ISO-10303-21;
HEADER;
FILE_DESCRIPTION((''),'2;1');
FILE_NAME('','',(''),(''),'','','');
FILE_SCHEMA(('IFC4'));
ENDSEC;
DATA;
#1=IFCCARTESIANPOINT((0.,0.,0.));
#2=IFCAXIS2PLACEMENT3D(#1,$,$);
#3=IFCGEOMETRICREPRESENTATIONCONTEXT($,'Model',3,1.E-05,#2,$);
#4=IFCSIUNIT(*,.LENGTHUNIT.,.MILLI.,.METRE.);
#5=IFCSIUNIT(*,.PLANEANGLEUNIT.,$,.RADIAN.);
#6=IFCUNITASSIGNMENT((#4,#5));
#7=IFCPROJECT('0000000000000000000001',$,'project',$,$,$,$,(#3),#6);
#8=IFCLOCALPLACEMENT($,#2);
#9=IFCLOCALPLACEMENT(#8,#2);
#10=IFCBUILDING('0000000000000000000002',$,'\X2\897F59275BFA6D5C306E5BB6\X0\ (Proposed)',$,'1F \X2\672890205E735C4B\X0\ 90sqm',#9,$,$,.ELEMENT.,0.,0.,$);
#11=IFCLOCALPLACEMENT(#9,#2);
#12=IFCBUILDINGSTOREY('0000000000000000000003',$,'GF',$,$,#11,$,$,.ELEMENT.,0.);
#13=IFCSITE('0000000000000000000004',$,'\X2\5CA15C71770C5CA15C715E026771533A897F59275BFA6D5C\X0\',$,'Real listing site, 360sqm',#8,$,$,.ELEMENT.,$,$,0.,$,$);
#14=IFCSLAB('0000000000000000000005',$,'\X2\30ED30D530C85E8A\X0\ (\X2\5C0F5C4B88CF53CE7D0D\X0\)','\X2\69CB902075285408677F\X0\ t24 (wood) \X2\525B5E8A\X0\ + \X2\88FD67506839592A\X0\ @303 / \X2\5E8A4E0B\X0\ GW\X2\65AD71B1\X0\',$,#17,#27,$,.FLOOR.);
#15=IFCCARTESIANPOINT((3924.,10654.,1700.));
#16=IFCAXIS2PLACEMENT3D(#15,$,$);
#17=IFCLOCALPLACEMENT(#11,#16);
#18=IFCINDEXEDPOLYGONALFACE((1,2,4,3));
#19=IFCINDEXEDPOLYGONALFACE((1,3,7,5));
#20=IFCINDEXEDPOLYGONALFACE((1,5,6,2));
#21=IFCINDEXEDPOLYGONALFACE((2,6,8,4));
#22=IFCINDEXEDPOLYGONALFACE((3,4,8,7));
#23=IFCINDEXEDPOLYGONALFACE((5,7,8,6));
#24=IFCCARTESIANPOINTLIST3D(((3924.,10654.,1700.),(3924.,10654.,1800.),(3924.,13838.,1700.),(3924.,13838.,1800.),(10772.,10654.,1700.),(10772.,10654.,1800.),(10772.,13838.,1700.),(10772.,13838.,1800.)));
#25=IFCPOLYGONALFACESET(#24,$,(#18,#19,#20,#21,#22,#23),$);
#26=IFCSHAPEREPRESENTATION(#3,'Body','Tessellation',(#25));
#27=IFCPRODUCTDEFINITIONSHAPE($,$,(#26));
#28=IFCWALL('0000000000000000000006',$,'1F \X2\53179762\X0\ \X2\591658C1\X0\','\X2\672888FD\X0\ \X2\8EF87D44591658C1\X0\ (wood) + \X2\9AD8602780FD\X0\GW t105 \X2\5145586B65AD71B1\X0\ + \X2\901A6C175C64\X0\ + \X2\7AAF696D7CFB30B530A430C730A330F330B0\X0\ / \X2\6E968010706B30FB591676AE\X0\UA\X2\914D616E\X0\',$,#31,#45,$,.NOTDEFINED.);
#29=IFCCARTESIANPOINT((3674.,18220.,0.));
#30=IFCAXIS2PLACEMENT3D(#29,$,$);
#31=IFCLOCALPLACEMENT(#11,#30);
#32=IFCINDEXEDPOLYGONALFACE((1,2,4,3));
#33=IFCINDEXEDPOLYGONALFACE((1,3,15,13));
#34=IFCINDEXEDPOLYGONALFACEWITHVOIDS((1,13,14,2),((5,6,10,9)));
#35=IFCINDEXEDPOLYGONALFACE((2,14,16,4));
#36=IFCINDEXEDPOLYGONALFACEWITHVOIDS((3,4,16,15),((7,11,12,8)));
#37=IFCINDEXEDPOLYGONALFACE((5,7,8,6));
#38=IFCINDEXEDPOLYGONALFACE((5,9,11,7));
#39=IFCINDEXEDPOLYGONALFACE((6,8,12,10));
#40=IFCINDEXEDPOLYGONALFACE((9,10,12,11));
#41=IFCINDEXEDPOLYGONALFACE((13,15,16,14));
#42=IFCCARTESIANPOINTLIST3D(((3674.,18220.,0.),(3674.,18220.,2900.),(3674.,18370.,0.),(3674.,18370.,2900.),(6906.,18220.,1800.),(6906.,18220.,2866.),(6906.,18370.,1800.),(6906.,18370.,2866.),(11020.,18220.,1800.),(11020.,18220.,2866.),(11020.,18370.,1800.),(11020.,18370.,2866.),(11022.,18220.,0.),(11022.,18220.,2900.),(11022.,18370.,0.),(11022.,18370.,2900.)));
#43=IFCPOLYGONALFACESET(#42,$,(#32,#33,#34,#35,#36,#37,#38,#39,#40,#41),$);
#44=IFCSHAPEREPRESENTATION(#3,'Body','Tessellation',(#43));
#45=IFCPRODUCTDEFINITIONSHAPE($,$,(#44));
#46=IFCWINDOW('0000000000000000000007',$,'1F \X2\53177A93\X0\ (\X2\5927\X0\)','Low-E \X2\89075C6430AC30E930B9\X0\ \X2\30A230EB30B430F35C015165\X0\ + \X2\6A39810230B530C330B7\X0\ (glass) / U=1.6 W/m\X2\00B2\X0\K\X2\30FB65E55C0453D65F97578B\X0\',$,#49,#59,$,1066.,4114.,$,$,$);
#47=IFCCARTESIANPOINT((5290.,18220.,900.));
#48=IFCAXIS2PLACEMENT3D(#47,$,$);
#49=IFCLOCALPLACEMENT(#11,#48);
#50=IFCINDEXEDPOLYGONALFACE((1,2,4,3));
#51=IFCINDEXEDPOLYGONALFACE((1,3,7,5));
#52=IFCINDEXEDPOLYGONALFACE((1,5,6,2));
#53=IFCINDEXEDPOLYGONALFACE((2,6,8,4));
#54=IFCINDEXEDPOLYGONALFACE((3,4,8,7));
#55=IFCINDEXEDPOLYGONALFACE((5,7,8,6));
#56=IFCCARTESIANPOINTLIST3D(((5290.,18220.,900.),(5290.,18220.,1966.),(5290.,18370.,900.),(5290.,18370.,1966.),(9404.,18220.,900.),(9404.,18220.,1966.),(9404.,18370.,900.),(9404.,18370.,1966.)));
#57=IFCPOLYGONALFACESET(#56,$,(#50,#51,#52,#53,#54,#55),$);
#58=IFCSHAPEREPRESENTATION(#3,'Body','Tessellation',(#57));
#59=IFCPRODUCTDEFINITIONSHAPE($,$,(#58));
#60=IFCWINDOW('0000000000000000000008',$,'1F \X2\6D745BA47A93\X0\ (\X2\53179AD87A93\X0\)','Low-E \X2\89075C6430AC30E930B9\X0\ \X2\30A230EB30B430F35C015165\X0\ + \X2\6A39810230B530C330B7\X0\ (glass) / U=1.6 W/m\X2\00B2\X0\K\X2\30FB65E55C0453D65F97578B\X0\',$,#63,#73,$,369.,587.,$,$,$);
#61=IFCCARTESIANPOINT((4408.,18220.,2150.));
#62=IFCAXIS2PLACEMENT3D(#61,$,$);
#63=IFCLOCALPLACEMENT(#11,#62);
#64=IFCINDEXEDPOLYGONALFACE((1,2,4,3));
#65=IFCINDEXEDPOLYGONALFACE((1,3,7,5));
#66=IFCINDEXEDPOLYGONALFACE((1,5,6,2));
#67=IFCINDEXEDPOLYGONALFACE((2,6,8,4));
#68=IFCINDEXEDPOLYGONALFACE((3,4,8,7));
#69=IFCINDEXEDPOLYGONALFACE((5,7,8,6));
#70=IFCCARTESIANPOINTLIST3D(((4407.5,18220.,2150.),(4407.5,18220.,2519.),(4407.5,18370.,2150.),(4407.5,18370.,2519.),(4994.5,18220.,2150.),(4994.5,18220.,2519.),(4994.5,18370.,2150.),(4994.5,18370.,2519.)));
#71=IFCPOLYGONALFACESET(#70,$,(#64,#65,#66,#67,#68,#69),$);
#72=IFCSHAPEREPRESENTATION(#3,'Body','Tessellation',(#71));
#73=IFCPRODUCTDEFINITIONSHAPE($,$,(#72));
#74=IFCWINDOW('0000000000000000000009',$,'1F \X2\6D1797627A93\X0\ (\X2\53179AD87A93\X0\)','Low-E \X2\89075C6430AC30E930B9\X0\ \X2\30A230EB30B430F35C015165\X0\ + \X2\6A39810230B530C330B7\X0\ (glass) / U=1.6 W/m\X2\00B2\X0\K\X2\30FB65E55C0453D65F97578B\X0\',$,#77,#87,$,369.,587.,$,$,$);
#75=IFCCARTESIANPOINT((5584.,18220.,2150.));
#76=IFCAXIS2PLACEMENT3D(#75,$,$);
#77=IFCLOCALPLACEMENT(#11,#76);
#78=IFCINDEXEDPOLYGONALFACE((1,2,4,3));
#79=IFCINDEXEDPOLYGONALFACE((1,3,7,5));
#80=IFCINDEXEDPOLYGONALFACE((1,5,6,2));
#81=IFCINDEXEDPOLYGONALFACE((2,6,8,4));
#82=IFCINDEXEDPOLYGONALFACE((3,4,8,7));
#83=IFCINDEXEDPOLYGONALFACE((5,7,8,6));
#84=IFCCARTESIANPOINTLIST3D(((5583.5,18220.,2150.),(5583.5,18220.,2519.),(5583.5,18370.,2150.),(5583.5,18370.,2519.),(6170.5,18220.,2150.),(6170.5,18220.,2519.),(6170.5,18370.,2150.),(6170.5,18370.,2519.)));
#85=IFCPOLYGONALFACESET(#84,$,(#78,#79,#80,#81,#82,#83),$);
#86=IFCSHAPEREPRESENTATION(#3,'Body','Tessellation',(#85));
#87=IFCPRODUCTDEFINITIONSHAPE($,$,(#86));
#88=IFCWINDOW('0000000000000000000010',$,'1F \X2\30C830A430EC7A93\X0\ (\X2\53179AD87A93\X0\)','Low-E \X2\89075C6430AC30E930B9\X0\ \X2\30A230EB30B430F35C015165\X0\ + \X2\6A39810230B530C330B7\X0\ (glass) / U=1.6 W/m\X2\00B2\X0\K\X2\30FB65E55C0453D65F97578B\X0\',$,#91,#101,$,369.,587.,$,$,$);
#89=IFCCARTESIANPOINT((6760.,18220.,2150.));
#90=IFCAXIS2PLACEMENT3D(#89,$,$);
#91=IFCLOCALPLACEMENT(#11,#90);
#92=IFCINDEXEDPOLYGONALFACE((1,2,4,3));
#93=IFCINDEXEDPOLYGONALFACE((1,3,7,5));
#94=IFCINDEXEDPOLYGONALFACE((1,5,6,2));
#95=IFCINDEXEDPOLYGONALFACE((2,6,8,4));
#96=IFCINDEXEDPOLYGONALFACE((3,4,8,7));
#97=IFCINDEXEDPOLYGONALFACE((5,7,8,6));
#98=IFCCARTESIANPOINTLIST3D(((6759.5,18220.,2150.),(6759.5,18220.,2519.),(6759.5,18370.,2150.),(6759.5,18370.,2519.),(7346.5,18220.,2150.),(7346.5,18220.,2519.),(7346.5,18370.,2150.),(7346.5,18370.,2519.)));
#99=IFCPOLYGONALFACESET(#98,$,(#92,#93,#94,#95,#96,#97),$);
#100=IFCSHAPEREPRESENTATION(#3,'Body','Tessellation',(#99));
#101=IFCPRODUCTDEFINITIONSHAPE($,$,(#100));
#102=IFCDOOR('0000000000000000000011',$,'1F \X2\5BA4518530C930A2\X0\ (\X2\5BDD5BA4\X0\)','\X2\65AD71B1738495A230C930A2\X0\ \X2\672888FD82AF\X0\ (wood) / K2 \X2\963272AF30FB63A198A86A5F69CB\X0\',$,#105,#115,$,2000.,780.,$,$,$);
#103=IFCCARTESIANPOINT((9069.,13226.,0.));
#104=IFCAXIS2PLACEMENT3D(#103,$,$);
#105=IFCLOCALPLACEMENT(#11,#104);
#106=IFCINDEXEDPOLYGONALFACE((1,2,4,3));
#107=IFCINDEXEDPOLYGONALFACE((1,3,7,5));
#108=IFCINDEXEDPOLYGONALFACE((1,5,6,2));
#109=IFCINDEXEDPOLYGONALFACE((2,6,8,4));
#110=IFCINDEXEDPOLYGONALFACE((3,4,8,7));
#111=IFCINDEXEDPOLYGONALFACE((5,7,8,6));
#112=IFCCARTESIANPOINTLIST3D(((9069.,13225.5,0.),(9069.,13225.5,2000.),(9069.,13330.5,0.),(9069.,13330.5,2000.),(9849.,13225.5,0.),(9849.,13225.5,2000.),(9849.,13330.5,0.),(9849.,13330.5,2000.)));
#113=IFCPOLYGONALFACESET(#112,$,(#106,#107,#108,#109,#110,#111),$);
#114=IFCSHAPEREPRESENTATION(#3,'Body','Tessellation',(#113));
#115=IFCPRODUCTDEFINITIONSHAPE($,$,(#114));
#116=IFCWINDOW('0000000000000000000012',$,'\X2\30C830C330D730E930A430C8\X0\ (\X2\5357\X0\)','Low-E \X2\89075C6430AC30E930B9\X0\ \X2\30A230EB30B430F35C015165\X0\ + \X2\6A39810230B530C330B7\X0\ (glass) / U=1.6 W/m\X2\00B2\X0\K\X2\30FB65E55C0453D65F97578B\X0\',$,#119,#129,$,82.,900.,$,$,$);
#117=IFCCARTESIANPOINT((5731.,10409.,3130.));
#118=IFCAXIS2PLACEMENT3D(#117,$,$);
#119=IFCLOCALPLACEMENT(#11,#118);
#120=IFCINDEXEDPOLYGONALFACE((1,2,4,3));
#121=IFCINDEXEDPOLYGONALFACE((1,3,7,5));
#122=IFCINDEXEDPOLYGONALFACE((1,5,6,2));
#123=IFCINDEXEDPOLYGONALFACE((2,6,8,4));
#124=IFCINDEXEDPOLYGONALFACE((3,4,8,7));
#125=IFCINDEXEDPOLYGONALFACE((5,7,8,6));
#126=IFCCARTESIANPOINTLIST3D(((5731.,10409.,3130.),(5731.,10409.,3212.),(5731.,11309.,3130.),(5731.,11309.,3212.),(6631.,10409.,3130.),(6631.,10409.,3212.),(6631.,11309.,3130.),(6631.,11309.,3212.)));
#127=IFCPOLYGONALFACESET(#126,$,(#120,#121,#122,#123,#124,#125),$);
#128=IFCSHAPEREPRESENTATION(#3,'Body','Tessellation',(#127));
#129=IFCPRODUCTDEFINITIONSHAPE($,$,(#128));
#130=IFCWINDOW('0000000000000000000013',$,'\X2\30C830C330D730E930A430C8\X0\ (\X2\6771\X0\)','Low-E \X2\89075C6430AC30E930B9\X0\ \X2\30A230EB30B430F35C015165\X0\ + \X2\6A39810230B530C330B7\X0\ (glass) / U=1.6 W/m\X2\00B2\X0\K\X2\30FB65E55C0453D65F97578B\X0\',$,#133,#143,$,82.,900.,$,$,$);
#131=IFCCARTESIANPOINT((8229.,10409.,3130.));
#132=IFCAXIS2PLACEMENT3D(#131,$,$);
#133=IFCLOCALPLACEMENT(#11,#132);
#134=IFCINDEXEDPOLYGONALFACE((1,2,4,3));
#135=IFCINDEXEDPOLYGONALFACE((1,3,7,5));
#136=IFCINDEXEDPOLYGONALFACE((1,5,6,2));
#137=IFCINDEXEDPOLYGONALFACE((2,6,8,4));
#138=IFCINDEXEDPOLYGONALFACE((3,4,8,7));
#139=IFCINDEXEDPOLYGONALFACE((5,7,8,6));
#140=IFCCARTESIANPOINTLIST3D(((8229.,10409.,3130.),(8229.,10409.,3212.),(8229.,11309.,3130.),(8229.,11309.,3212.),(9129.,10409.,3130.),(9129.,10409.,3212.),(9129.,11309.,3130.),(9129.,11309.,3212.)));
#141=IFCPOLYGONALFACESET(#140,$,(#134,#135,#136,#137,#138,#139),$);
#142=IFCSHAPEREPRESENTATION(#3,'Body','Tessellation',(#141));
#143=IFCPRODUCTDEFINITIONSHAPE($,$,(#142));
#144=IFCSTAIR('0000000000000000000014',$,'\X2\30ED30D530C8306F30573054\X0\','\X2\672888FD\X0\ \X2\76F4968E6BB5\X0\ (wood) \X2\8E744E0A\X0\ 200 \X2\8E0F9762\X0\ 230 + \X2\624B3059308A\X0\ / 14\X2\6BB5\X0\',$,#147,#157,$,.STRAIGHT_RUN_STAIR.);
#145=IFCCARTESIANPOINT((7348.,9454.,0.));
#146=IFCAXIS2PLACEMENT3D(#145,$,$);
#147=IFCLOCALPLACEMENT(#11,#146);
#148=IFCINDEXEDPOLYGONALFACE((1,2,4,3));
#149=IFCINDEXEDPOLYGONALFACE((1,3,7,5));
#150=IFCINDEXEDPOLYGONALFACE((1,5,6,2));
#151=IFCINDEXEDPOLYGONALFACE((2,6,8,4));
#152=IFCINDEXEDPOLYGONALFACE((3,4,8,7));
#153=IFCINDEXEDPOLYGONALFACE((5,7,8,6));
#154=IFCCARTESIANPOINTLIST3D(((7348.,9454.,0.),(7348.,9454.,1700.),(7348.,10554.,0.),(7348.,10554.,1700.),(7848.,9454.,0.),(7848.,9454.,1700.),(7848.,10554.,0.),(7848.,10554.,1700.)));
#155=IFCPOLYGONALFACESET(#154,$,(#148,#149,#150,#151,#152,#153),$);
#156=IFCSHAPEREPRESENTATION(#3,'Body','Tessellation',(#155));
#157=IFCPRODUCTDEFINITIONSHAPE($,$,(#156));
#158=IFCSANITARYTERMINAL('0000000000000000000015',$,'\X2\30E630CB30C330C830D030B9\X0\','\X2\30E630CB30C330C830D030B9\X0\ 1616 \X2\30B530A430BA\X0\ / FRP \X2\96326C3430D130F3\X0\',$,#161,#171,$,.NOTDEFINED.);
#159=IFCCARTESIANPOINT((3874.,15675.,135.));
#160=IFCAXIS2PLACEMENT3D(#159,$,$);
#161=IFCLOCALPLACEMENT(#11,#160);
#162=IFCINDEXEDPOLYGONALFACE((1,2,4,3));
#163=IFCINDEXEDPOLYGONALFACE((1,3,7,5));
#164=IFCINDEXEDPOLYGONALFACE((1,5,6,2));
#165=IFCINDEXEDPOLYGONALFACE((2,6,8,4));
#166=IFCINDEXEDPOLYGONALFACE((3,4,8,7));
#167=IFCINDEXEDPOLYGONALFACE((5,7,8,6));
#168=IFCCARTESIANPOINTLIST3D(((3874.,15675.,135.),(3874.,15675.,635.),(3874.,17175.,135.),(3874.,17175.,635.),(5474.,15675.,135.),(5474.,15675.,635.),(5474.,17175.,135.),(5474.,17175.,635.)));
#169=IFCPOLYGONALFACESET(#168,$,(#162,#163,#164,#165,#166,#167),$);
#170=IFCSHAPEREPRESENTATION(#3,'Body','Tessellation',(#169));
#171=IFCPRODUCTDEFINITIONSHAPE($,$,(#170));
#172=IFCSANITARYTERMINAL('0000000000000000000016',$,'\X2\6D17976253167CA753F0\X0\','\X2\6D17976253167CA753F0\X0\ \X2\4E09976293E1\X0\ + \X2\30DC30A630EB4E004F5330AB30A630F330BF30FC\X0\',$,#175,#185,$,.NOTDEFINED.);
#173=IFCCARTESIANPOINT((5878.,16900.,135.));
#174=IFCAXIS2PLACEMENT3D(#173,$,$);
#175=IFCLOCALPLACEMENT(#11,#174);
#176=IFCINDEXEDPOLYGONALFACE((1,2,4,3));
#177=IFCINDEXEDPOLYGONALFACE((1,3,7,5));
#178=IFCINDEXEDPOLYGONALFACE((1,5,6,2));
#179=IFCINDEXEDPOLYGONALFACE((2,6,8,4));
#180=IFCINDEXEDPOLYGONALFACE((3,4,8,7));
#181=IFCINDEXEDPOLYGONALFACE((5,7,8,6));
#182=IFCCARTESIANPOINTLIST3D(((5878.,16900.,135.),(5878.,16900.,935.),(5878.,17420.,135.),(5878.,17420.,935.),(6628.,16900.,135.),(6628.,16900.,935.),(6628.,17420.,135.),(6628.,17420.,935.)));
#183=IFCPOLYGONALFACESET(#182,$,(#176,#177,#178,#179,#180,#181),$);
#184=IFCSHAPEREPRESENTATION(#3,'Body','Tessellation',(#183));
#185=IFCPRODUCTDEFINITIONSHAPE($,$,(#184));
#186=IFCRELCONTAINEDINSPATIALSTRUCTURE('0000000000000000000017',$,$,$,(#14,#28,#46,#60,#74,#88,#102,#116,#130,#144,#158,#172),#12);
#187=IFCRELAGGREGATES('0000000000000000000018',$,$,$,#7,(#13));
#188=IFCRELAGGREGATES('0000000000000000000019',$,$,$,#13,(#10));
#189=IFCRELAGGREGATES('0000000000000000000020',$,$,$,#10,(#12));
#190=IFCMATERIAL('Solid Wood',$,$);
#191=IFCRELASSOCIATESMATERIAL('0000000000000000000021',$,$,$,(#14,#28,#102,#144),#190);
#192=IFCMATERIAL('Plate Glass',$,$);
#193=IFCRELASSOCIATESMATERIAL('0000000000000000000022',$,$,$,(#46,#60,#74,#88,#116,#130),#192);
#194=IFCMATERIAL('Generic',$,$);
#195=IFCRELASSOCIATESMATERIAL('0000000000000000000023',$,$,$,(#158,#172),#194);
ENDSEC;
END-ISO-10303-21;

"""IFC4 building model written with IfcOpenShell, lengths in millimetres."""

from ifc_helpers import new_model, si_unit, frame, frame_2d, origin, place, context, project, spatial, rectangle, extrude, material, element, fill, save


model = new_model("IFC4")

# Units and contexts
model_context = context("Model", 3, precision=1e-05, world=origin())
ifc_project = project(units=[si_unit("LENGTHUNIT", "METRE", prefix="MILLI"), si_unit("PLANEANGLEUNIT", "RADIAN")], contexts=[model_context])

# Site, building, storey
site_placement = place(None, origin())
site = spatial("IfcSite", under=ifc_project, at=site_placement, Name="岡山県岡山市東区西大寺浜", ObjectType="Real listing site, 360sqm", CompositionType="ELEMENT", RefElevation=0.0)
building_placement = place(site_placement, origin())
building = spatial("IfcBuilding", under=site, at=building_placement, Name="西大寺浜の家 (Proposed)", ObjectType="1F 木造平屋 90sqm", CompositionType="ELEMENT", ElevationOfRefHeight=0.0, ElevationOfTerrain=0.0)
storey_placement = place(building_placement, origin())
storey = spatial("IfcBuildingStorey", under=building, at=storey_placement, Name="GF", CompositionType="ELEMENT", Elevation=0.0)

# Slab
ifc_material_1 = material(Name="Solid Wood")
slab_placement = place(storey_placement, frame((3924.0, 10654.0, 1700.0)))
element("IfcSlab", 1, at=slab_placement, inside=storey, material=ifc_material_1, Name="ロフト床 (小屋裏収納)", Description="構造用合板 t24 (wood) 剛床 + 製材根太 @303 / 床下 GW断熱", PredefinedType="FLOOR", context=model_context, shape_type="SweptSolid", body=[
    extrude(rectangle(XDim=6848.0, YDim=3184.0, at=frame_2d((3424.0, 1592.0))), frame((3924.0, 10654.0, 1700.0)), (0.0, 0.0, 1.0), 100.0),
])

# Wall, openings, windows
wall_1_placement = place(storey_placement, frame((3674.0, 18220.0, 0.0)))
wall_1 = element("IfcWall", 2, at=wall_1_placement, inside=storey, material=ifc_material_1, Name="1F 北面 外壁", Description="木製 軸組外壁 (wood) + 高性能GW t105 充填断熱 + 通気層 + 窯業系サイディング / 準耐火・外皮UA配慮", PredefinedType="NOTDEFINED", context=model_context, shape_type="SweptSolid", body=[
    extrude(rectangle(XDim=7348.0, YDim=150.0, at=frame_2d((3674.0, 75.0))), frame((3674.0, 18220.0, 0.0)), (0.0, 0.0, 1.0), 2900.0),
])
opening_1_placement = place(storey_placement, frame((5290.0, 18220.0, 900.0)))
opening_1 = element("IfcOpeningElement", 3, at=opening_1_placement, cuts=wall_1, PredefinedType="NOTDEFINED", context=model_context, shape_type="SweptSolid", body=[
    extrude(rectangle(XDim=4114.0, YDim=150.0, at=frame_2d((2057.0, 75.0))), frame((5290.0, 18220.0, 900.0)), (0.0, 0.0, 1.0), 1066.0),
])
opening_2_placement = place(storey_placement, frame((4408.0, 18220.0, 2150.0)))
opening_2 = element("IfcOpeningElement", 4, at=opening_2_placement, cuts=wall_1, PredefinedType="NOTDEFINED", context=model_context, shape_type="SweptSolid", body=[
    extrude(rectangle(XDim=587.0, YDim=150.0, at=frame_2d((293.0, 75.0))), frame((4408.0, 18220.0, 2150.0)), (0.0, 0.0, 1.0), 369.0),
])
opening_3_placement = place(storey_placement, frame((5584.0, 18220.0, 2150.0)))
opening_3 = element("IfcOpeningElement", 5, at=opening_3_placement, cuts=wall_1, PredefinedType="NOTDEFINED", context=model_context, shape_type="SweptSolid", body=[
    extrude(rectangle(XDim=587.0, YDim=150.0, at=frame_2d((293.0, 75.0))), frame((5584.0, 18220.0, 2150.0)), (0.0, 0.0, 1.0), 369.0),
])
opening_4_placement = place(storey_placement, frame((6760.0, 18220.0, 2150.0)))
opening_4 = element("IfcOpeningElement", 6, at=opening_4_placement, cuts=wall_1, PredefinedType="NOTDEFINED", context=model_context, shape_type="SweptSolid", body=[
    extrude(rectangle(XDim=587.0, YDim=150.0, at=frame_2d((293.0, 75.0))), frame((6760.0, 18220.0, 2150.0)), (0.0, 0.0, 1.0), 369.0),
])
ifc_material_2 = material(Name="Plate Glass")
window_1_placement = place(storey_placement, frame((5290.0, 18220.0, 900.0)))
window_1 = element("IfcWindow", 7, at=window_1_placement, inside=storey, material=ifc_material_2, Name="1F 北窓 (大)", Description="Low-E 複層ガラス アルゴン封入 + 樹脂サッシ (glass) / U=1.6 W/m²K・日射取得型", OverallHeight=1066.0, OverallWidth=4114.0, context=model_context, shape_type="SweptSolid", body=[
    extrude(rectangle(XDim=4114.0, YDim=150.0, at=frame_2d((2057.0, 75.0))), frame((5290.0, 18220.0, 900.0)), (0.0, 0.0, 1.0), 1066.0),
])
fill(opening_1, window_1)
window_2_placement = place(storey_placement, frame((4408.0, 18220.0, 2150.0)))
window_2 = element("IfcWindow", 8, at=window_2_placement, inside=storey, material=ifc_material_2, Name="1F 浴室窓 (北高窓)", Description="Low-E 複層ガラス アルゴン封入 + 樹脂サッシ (glass) / U=1.6 W/m²K・日射取得型", OverallHeight=369.0, OverallWidth=587.0, context=model_context, shape_type="SweptSolid", body=[
    extrude(rectangle(XDim=587.0, YDim=150.0, at=frame_2d((293.0, 75.0))), frame((4408.0, 18220.0, 2150.0)), (0.0, 0.0, 1.0), 369.0),
])
fill(opening_2, window_2)
window_3_placement = place(storey_placement, frame((5584.0, 18220.0, 2150.0)))
window_3 = element("IfcWindow", 9, at=window_3_placement, inside=storey, material=ifc_material_2, Name="1F 洗面窓 (北高窓)", Description="Low-E 複層ガラス アルゴン封入 + 樹脂サッシ (glass) / U=1.6 W/m²K・日射取得型", OverallHeight=369.0, OverallWidth=587.0, context=model_context, shape_type="SweptSolid", body=[
    extrude(rectangle(XDim=587.0, YDim=150.0, at=frame_2d((293.0, 75.0))), frame((5584.0, 18220.0, 2150.0)), (0.0, 0.0, 1.0), 369.0),
])
fill(opening_3, window_3)
window_4_placement = place(storey_placement, frame((6760.0, 18220.0, 2150.0)))
window_4 = element("IfcWindow", 10, at=window_4_placement, inside=storey, material=ifc_material_2, Name="1F トイレ窓 (北高窓)", Description="Low-E 複層ガラス アルゴン封入 + 樹脂サッシ (glass) / U=1.6 W/m²K・日射取得型", OverallHeight=369.0, OverallWidth=587.0, context=model_context, shape_type="SweptSolid", body=[
    extrude(rectangle(XDim=587.0, YDim=150.0, at=frame_2d((293.0, 75.0))), frame((6760.0, 18220.0, 2150.0)), (0.0, 0.0, 1.0), 369.0),
])
fill(opening_4, window_4)

# Door
door_1_placement = place(storey_placement, frame((9069.0, 13226.0, 0.0)))
element("IfcDoor", 11, at=door_1_placement, inside=storey, material=ifc_material_1, Name="1F 室内ドア (寝室)", Description="断熱玄関ドア 木製芯 (wood) / K2 防犯・採風機構", OverallHeight=2000.0, OverallWidth=780.0, context=model_context, shape_type="SweptSolid", body=[
    extrude(rectangle(XDim=780.0, YDim=105.0, at=frame_2d((390.0, 52.0))), frame((9069.0, 13226.0, 0.0)), (0.0, 0.0, 1.0), 2000.0),
])

# Windows
window_5_placement = place(storey_placement, frame((5731.0, 10409.0, 3130.0)))
element("IfcWindow", 12, at=window_5_placement, inside=storey, material=ifc_material_2, Name="トップライト (南)", Description="Low-E 複層ガラス アルゴン封入 + 樹脂サッシ (glass) / U=1.6 W/m²K・日射取得型", OverallHeight=82.0, OverallWidth=900.0, context=model_context, shape_type="SweptSolid", body=[
    extrude(rectangle(XDim=900.0, YDim=900.0, at=frame_2d((450.0, 450.0))), frame((5731.0, 10409.0, 3130.0)), (0.0, 0.0, 1.0), 82.0),
])
window_6_placement = place(storey_placement, frame((8229.0, 10409.0, 3130.0)))
element("IfcWindow", 13, at=window_6_placement, inside=storey, material=ifc_material_2, Name="トップライト (東)", Description="Low-E 複層ガラス アルゴン封入 + 樹脂サッシ (glass) / U=1.6 W/m²K・日射取得型", OverallHeight=82.0, OverallWidth=900.0, context=model_context, shape_type="SweptSolid", body=[
    extrude(rectangle(XDim=900.0, YDim=900.0, at=frame_2d((450.0, 450.0))), frame((8229.0, 10409.0, 3130.0)), (0.0, 0.0, 1.0), 82.0),
])

# Stair
stair_placement = place(storey_placement, frame((7348.0, 9454.0, 0.0)))
element("IfcStair", 14, at=stair_placement, inside=storey, material=ifc_material_1, Name="ロフトはしご", Description="木製 直階段 (wood) 蹴上 200 踏面 230 + 手すり / 14段", PredefinedType="STRAIGHT_RUN_STAIR", context=model_context, shape_type="SweptSolid", body=[
    extrude(rectangle(XDim=500.0, YDim=1100.0, at=frame_2d((250.0, 550.0))), frame((7348.0, 9454.0, 0.0)), (0.0, 0.0, 1.0), 1700.0),
])

# Sanitary terminals
ifc_material_3 = material(Name="Generic")
sanitary_terminal_1_placement = place(storey_placement, frame((3874.0, 15675.0, 135.0)))
element("IfcSanitaryTerminal", 15, at=sanitary_terminal_1_placement, inside=storey, material=ifc_material_3, Name="ユニットバス", Description="ユニットバス 1616 サイズ / FRP 防水パン", PredefinedType="NOTDEFINED", context=model_context, shape_type="SweptSolid", body=[
    extrude(rectangle(XDim=1600.0, YDim=1500.0, at=frame_2d((800.0, 750.0))), frame((3874.0, 15675.0, 135.0)), (0.0, 0.0, 1.0), 500.0),
])
sanitary_terminal_2_placement = place(storey_placement, frame((5878.0, 16900.0, 135.0)))
element("IfcSanitaryTerminal", 16, at=sanitary_terminal_2_placement, inside=storey, material=ifc_material_3, Name="洗面化粧台", Description="洗面化粧台 三面鏡 + ボウル一体カウンター", PredefinedType="NOTDEFINED", context=model_context, shape_type="SweptSolid", body=[
    extrude(rectangle(XDim=750.0, YDim=520.0, at=frame_2d((375.0, 260.0))), frame((5878.0, 16900.0, 135.0)), (0.0, 0.0, 1.0), 800.0),
])

save(model, "model.ifc")
